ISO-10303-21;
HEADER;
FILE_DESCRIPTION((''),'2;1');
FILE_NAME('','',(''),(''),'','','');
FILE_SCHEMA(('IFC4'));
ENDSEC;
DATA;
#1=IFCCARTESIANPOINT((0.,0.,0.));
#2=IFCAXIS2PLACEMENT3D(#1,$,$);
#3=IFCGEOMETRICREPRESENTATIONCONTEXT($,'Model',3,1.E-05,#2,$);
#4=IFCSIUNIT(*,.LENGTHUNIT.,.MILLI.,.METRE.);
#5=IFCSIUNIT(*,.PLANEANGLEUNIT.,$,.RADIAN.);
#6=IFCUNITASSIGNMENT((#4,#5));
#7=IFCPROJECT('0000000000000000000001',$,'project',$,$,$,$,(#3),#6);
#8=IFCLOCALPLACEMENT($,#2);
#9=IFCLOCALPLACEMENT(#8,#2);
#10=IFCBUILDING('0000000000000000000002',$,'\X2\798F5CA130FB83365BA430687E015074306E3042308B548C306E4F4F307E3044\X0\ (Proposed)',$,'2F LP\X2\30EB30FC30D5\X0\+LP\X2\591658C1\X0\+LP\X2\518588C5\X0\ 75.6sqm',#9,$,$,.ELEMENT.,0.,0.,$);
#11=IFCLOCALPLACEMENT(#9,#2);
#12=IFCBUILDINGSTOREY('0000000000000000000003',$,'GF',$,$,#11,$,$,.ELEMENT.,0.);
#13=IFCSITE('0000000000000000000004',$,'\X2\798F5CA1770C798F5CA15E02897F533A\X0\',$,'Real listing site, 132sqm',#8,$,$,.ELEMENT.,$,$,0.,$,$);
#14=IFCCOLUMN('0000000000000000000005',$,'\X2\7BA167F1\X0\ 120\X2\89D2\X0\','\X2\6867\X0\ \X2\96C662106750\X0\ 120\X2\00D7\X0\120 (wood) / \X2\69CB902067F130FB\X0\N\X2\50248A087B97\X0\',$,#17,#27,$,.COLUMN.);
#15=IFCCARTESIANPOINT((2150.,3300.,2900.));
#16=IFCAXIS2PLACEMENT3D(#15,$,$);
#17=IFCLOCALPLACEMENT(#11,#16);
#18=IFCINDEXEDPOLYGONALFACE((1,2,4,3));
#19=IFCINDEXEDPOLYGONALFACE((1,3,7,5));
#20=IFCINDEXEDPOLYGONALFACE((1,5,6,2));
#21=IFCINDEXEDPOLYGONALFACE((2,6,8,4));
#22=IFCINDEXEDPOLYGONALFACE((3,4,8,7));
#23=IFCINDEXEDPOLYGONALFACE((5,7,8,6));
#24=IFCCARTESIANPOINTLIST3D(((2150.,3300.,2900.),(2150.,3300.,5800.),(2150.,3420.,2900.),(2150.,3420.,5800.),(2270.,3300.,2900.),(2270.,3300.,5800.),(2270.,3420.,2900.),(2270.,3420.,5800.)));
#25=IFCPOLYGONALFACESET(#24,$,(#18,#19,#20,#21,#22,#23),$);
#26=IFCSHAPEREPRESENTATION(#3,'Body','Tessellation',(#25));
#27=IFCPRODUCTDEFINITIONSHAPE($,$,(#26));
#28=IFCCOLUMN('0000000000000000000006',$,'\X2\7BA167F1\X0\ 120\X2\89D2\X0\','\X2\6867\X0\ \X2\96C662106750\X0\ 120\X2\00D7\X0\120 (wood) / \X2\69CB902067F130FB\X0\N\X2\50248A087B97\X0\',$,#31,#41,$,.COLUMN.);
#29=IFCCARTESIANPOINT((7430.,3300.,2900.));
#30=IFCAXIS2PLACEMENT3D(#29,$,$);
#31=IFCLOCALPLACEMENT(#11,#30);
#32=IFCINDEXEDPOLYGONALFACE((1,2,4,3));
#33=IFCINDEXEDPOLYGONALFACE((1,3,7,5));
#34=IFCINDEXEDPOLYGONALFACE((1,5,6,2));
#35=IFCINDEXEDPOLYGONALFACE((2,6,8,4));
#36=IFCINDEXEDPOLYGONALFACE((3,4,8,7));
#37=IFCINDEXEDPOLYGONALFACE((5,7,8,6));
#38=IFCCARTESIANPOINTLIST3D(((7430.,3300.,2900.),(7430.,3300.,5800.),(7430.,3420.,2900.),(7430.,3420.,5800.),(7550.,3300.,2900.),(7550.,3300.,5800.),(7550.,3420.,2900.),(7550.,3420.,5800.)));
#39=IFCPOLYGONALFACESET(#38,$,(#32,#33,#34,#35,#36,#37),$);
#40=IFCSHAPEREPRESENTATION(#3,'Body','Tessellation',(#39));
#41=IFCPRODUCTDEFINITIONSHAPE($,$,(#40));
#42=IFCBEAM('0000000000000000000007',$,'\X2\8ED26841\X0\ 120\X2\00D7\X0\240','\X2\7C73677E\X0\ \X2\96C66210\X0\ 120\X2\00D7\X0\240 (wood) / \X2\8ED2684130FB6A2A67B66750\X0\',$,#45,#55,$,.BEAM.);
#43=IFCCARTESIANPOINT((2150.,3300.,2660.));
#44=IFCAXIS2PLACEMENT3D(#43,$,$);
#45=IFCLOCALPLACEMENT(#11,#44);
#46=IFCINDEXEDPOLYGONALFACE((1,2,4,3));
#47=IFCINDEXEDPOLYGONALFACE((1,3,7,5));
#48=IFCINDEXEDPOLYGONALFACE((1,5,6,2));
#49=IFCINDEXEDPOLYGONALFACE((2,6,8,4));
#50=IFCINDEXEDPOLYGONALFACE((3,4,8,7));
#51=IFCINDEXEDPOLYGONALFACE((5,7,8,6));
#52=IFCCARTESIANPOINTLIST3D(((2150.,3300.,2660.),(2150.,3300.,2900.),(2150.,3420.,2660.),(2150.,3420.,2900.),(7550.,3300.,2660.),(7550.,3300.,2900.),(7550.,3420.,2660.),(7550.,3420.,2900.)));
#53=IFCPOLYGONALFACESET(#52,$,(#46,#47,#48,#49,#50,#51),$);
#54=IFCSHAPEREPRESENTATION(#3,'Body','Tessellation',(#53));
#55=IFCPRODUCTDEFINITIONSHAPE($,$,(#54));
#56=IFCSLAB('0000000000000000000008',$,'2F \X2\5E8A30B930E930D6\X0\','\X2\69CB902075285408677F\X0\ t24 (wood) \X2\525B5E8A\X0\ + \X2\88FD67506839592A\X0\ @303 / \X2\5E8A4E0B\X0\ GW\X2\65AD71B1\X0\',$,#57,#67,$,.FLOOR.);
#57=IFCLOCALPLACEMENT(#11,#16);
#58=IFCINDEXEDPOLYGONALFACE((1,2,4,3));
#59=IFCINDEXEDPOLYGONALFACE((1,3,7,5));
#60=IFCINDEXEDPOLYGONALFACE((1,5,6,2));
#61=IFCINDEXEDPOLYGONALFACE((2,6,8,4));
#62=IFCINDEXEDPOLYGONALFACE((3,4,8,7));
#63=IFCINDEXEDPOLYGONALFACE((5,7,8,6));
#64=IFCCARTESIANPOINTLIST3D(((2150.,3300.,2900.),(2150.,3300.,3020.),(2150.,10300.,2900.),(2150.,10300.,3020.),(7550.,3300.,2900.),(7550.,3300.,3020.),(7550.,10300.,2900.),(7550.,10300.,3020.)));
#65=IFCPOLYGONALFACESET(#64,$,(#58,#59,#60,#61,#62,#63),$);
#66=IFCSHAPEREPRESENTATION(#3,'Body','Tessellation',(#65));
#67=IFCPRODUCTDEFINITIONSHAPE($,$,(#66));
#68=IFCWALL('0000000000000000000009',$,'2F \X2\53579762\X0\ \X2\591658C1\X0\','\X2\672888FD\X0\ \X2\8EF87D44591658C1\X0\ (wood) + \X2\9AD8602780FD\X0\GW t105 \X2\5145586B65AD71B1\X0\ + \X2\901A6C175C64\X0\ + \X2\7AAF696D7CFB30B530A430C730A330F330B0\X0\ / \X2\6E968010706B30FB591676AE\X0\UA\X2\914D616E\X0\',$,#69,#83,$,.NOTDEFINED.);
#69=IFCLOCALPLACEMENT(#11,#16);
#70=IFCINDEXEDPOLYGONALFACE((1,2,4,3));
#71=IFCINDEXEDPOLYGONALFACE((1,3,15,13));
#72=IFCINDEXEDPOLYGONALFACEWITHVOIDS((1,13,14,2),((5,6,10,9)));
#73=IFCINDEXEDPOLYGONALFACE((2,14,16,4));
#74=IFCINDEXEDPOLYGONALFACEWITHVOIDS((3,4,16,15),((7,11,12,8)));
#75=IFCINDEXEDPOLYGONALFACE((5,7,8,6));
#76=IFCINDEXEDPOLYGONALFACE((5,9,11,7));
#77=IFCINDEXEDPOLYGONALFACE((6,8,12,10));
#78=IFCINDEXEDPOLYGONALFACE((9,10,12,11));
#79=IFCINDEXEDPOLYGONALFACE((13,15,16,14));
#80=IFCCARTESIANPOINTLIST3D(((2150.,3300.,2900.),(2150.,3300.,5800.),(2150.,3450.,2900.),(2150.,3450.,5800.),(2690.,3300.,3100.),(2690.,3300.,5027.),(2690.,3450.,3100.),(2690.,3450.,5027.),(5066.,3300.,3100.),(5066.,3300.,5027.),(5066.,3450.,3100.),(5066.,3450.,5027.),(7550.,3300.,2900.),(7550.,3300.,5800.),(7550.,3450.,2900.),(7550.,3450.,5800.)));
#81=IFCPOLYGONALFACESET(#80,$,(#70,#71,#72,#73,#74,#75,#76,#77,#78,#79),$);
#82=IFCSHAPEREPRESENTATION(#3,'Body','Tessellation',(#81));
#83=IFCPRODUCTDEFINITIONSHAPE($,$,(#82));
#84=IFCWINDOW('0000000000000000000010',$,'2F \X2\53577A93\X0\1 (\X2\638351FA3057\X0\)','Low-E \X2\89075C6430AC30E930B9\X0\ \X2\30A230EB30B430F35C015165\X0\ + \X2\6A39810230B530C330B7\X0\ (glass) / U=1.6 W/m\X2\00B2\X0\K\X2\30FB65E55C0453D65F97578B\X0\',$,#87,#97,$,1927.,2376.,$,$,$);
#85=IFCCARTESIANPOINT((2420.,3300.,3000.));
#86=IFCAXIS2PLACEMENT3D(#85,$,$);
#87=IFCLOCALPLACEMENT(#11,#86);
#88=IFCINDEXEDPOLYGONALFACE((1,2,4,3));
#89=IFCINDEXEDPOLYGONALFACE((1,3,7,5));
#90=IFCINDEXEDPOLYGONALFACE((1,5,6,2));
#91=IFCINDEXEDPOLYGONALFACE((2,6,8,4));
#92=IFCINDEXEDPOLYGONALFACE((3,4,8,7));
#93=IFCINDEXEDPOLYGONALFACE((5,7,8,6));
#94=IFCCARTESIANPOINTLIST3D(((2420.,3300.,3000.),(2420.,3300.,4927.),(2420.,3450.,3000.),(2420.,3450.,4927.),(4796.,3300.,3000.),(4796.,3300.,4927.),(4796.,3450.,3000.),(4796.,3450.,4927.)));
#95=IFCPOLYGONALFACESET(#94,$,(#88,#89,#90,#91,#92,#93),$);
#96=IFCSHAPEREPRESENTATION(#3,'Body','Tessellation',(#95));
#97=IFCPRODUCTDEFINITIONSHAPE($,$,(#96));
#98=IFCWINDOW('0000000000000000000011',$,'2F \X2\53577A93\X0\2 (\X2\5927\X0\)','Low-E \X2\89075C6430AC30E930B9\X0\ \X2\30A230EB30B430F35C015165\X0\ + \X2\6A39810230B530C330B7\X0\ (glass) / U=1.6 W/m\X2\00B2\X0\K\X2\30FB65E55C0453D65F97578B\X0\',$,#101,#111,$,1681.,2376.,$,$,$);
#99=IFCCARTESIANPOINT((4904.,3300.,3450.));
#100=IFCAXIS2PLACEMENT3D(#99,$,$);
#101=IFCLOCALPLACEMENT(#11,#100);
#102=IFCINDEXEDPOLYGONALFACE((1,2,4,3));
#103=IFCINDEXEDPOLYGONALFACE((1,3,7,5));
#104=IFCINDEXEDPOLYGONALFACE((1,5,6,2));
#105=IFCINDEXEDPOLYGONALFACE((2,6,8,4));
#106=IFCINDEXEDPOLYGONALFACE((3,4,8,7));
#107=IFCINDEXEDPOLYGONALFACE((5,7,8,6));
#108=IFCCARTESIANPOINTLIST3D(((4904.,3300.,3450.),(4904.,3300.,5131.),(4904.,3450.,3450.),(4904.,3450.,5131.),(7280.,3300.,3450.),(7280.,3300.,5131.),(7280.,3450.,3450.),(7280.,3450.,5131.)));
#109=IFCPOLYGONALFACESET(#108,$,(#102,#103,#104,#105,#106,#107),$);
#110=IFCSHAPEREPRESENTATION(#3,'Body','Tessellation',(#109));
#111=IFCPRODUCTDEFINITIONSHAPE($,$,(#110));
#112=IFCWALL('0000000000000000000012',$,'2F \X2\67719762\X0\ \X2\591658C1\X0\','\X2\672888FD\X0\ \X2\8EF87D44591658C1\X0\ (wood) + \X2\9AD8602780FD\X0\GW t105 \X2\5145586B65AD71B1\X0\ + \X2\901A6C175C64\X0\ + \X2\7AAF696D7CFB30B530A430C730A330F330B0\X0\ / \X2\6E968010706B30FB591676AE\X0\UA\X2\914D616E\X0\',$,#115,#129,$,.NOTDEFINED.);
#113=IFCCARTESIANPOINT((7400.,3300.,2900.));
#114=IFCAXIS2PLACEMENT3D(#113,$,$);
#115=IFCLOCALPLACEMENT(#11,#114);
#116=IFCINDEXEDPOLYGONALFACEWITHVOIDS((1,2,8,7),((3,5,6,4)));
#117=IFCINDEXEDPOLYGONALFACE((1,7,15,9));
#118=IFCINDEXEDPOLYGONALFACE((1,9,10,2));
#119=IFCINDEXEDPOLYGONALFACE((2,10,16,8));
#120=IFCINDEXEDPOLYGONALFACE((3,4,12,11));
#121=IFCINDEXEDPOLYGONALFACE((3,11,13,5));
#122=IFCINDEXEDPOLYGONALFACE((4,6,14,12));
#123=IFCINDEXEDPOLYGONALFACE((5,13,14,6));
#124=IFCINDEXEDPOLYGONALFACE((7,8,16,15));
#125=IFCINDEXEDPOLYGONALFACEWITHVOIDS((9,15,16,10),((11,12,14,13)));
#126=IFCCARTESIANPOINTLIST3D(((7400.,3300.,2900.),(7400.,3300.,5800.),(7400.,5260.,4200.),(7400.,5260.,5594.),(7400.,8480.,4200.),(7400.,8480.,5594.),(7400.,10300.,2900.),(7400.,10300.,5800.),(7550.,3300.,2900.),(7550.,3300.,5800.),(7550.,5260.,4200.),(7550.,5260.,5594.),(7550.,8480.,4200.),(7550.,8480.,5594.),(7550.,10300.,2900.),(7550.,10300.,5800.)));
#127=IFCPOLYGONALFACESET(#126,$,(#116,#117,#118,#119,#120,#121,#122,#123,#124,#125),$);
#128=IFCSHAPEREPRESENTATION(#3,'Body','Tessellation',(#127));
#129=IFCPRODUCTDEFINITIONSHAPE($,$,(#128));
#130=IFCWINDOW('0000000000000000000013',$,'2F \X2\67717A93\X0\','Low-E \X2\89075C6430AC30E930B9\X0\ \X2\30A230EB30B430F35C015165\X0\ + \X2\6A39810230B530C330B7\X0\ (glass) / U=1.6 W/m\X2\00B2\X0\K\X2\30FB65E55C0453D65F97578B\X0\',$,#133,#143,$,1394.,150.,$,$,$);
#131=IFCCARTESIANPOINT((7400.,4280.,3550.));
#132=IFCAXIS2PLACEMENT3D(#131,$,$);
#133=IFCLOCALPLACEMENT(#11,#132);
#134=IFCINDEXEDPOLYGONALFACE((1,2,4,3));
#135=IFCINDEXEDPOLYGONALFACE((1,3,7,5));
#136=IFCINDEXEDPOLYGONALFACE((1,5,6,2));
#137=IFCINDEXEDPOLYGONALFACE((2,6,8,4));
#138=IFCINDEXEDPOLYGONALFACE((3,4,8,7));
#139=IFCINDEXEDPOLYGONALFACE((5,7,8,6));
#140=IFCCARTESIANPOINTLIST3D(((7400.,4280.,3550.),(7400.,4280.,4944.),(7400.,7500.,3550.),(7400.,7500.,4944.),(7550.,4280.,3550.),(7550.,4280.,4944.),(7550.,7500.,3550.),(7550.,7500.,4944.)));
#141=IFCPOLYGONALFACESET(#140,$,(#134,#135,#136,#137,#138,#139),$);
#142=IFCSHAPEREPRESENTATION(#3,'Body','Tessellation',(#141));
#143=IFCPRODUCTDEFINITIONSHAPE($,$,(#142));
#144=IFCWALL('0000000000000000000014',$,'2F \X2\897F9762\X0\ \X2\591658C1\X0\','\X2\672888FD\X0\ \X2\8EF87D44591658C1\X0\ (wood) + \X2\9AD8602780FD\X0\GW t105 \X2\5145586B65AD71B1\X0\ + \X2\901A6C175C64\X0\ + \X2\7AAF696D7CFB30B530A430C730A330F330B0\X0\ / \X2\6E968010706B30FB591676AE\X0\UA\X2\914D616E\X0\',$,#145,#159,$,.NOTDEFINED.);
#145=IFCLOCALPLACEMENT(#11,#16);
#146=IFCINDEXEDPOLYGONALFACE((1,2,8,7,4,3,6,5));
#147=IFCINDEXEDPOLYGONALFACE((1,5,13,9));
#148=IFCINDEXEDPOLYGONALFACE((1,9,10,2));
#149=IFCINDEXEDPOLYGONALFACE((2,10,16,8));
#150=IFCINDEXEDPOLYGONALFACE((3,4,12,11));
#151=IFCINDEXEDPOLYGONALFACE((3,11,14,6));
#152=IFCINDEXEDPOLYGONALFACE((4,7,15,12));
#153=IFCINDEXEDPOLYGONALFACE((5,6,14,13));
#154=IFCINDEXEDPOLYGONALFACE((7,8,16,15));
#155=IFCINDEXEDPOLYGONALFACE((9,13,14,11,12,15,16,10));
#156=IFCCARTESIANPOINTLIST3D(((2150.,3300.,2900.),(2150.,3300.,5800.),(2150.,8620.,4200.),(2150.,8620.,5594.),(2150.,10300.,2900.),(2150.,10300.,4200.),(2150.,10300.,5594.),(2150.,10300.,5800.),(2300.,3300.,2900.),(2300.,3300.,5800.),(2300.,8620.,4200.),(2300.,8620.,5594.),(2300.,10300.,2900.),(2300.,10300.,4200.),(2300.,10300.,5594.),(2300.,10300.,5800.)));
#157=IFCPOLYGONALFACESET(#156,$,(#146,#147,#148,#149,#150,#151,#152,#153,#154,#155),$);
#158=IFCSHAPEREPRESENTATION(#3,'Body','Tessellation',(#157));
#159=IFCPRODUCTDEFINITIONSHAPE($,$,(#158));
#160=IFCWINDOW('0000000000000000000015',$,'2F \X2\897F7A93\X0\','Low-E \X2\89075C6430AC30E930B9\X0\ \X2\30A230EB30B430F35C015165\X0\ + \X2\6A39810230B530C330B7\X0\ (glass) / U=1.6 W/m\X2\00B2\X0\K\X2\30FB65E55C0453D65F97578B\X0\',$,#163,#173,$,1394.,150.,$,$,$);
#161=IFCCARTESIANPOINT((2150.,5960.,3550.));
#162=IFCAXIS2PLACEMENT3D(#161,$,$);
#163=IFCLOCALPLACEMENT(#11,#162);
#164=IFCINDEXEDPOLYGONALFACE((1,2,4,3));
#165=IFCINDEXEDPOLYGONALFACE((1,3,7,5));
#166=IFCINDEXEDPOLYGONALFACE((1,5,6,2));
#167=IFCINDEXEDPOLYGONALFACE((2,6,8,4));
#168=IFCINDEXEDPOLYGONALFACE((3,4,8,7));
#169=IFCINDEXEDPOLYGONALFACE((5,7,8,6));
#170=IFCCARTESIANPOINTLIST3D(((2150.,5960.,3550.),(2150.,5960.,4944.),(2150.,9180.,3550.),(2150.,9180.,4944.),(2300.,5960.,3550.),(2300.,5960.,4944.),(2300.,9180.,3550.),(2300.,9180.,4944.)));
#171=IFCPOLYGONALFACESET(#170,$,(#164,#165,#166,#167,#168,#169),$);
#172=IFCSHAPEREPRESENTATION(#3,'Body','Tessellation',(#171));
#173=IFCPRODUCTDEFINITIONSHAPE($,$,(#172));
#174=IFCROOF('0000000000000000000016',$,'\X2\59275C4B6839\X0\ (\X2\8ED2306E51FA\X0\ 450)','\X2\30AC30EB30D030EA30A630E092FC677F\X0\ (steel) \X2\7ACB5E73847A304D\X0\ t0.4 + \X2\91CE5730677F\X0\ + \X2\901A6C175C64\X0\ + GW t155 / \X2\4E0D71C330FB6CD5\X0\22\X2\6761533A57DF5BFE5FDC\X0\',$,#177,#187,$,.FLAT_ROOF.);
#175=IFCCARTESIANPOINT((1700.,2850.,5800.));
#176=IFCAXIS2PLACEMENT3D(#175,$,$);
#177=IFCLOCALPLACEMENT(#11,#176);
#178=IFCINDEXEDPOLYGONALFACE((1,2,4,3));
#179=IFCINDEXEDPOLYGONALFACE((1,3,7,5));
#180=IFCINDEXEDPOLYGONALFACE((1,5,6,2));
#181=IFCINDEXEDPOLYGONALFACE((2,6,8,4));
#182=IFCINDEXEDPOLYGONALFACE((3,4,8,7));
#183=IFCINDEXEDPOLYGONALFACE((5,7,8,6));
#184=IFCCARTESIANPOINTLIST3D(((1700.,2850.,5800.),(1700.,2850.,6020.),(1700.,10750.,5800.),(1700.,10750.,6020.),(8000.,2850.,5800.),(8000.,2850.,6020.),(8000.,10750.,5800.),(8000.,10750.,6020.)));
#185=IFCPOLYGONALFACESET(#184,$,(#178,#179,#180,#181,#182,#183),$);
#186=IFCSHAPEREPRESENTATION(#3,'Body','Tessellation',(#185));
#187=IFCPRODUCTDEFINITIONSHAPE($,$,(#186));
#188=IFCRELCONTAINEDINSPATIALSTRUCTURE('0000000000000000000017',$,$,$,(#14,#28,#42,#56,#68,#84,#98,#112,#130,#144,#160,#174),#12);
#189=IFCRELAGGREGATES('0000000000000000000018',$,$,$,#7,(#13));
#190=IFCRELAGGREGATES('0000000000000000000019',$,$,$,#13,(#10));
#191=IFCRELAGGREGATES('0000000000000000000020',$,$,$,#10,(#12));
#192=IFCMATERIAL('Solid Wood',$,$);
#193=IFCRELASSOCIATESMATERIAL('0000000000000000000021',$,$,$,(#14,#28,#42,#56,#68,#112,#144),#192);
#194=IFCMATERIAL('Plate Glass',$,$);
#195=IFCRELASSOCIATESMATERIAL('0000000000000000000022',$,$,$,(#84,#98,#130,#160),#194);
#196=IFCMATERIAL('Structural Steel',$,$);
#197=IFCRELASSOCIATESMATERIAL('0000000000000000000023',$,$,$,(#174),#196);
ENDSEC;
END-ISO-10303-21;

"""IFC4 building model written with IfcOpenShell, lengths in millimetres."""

from ifc_helpers import new_model, si_unit, frame, frame_2d, origin, place, context, project, spatial, rectangle, extrude, material, element, fill, save


model = new_model("IFC4")

# Units and contexts
model_context = context("Model", 3, precision=1e-05, world=origin())
ifc_project = project(units=[si_unit("LENGTHUNIT", "METRE", prefix="MILLI"), si_unit("PLANEANGLEUNIT", "RADIAN")], contexts=[model_context])

# Site, building, storey
site_placement = place(None, origin())
site = spatial("IfcSite", under=ifc_project, at=site_placement, Name="福岡県福岡市西区", ObjectType="Real listing site, 132sqm", CompositionType="ELEMENT", RefElevation=0.0)
building_placement = place(site_placement, origin())
building = spatial("IfcBuilding", under=site, at=building_placement, Name="福岡・茶室と縁側のある和の住まい (Proposed)", ObjectType="2F LPルーフ+LP外壁+LP内装 75.6sqm", CompositionType="ELEMENT", ElevationOfRefHeight=0.0, ElevationOfTerrain=0.0)
storey_placement = place(building_placement, origin())
storey = spatial("IfcBuildingStorey", under=building, at=storey_placement, Name="GF", CompositionType="ELEMENT", Elevation=0.0)

# Columns
ifc_material_1 = material(Name="Solid Wood")
column_1_placement = place(storey_placement, frame((2150.0, 3300.0, 2900.0)))
element("IfcColumn", 1, at=column_1_placement, inside=storey, material=ifc_material_1, Name="管柱 120角", Description="桧 集成材 120×120 (wood) / 構造柱・N値計算", PredefinedType="COLUMN", context=model_context, shape_type="SweptSolid", body=[
    extrude(rectangle(XDim=120.0, YDim=120.0, at=frame_2d((60.0, 60.0))), frame((2150.0, 3300.0, 2900.0)), (0.0, 0.0, 1.0), 2900.0),
])
column_2_placement = place(storey_placement, frame((7430.0, 3300.0, 2900.0)))
element("IfcColumn", 2, at=column_2_placement, inside=storey, material=ifc_material_1, Name="管柱 120角", Description="桧 集成材 120×120 (wood) / 構造柱・N値計算", PredefinedType="COLUMN", context=model_context, shape_type="SweptSolid", body=[
    extrude(rectangle(XDim=120.0, YDim=120.0, at=frame_2d((60.0, 60.0))), frame((7430.0, 3300.0, 2900.0)), (0.0, 0.0, 1.0), 2900.0),
])

# Beam
beam_1_placement = place(storey_placement, frame((2150.0, 3300.0, 2660.0)))
element("IfcBeam", 3, at=beam_1_placement, inside=storey, material=ifc_material_1, Name="軒桁 120×240", Description="米松 集成 120×240 (wood) / 軒桁・横架材", PredefinedType="BEAM", context=model_context, shape_type="SweptSolid", body=[
    extrude(rectangle(XDim=5400.0, YDim=120.0, at=frame_2d((2700.0, 60.0))), frame((2150.0, 3300.0, 2660.0)), (0.0, 0.0, 1.0), 240.0),
])

# Slab
slab_placement = place(storey_placement, frame((2150.0, 3300.0, 2900.0)))
element("IfcSlab", 4, at=slab_placement, inside=storey, material=ifc_material_1, Name="2F 床スラブ", Description="構造用合板 t24 (wood) 剛床 + 製材根太 @303 / 床下 GW断熱", PredefinedType="FLOOR", context=model_context, shape_type="SweptSolid", body=[
    extrude(rectangle(XDim=5400.0, YDim=7000.0, at=frame_2d((2700.0, 3500.0))), frame((2150.0, 3300.0, 2900.0)), (0.0, 0.0, 1.0), 120.0),
])

# Wall, openings, windows
wall_1_placement = place(storey_placement, frame((2150.0, 3300.0, 2900.0)))
wall_1 = element("IfcWall", 5, at=wall_1_placement, inside=storey, material=ifc_material_1, Name="2F 南面 外壁", Description="木製 軸組外壁 (wood) + 高性能GW t105 充填断熱 + 通気層 + 窯業系サイディング / 準耐火・外皮UA配慮", PredefinedType="NOTDEFINED", context=model_context, shape_type="SweptSolid", body=[
    extrude(rectangle(XDim=5400.0, YDim=150.0, at=frame_2d((2700.0, 75.0))), frame((2150.0, 3300.0, 2900.0)), (0.0, 0.0, 1.0), 2900.0),
])
opening_1_placement = place(storey_placement, frame((2420.0, 3300.0, 3000.0)))
opening_1 = element("IfcOpeningElement", 6, at=opening_1_placement, cuts=wall_1, PredefinedType="NOTDEFINED", context=model_context, shape_type="SweptSolid", body=[
    extrude(rectangle(XDim=2376.0, YDim=150.0, at=frame_2d((1188.0, 75.0))), frame((2420.0, 3300.0, 3000.0)), (0.0, 0.0, 1.0), 1927.0),
])
opening_2_placement = place(storey_placement, frame((4904.0, 3300.0, 3450.0)))
opening_2 = element("IfcOpeningElement", 7, at=opening_2_placement, cuts=wall_1, PredefinedType="NOTDEFINED", context=model_context, shape_type="SweptSolid", body=[
    extrude(rectangle(XDim=2376.0, YDim=150.0, at=frame_2d((1188.0, 75.0))), frame((4904.0, 3300.0, 3450.0)), (0.0, 0.0, 1.0), 1681.0),
])
ifc_material_2 = material(Name="Plate Glass")
window_1_placement = place(storey_placement, frame((2420.0, 3300.0, 3000.0)))
window_1 = element("IfcWindow", 8, at=window_1_placement, inside=storey, material=ifc_material_2, Name="2F 南窓1 (掃出し)", Description="Low-E 複層ガラス アルゴン封入 + 樹脂サッシ (glass) / U=1.6 W/m²K・日射取得型", OverallHeight=1927.0, OverallWidth=2376.0, context=model_context, shape_type="SweptSolid", body=[
    extrude(rectangle(XDim=2376.0, YDim=150.0, at=frame_2d((1188.0, 75.0))), frame((2420.0, 3300.0, 3000.0)), (0.0, 0.0, 1.0), 1927.0),
])
fill(opening_1, window_1)
window_2_placement = place(storey_placement, frame((4904.0, 3300.0, 3450.0)))
window_2 = element("IfcWindow", 9, at=window_2_placement, inside=storey, material=ifc_material_2, Name="2F 南窓2 (大)", Description="Low-E 複層ガラス アルゴン封入 + 樹脂サッシ (glass) / U=1.6 W/m²K・日射取得型", OverallHeight=1681.0, OverallWidth=2376.0, context=model_context, shape_type="SweptSolid", body=[
    extrude(rectangle(XDim=2376.0, YDim=150.0, at=frame_2d((1188.0, 75.0))), frame((4904.0, 3300.0, 3450.0)), (0.0, 0.0, 1.0), 1681.0),
])
fill(opening_2, window_2)

# Walls, openings, windows
wall_2_placement = place(storey_placement, frame((7400.0, 3300.0, 2900.0)))
wall_2 = element("IfcWall", 10, at=wall_2_placement, inside=storey, material=ifc_material_1, Name="2F 東面 外壁", Description="木製 軸組外壁 (wood) + 高性能GW t105 充填断熱 + 通気層 + 窯業系サイディング / 準耐火・外皮UA配慮", PredefinedType="NOTDEFINED", context=model_context, shape_type="SweptSolid", body=[
    extrude(rectangle(XDim=150.0, YDim=7000.0, at=frame_2d((75.0, 3500.0))), frame((7400.0, 3300.0, 2900.0)), (0.0, 0.0, 1.0), 2900.0),
])
opening_3_placement = place(storey_placement, frame((7400.0, 4280.0, 3550.0)))
opening_3 = element("IfcOpeningElement", 11, at=opening_3_placement, cuts=wall_2, PredefinedType="NOTDEFINED", context=model_context, shape_type="SweptSolid", body=[
    extrude(rectangle(XDim=150.0, YDim=3220.0, at=frame_2d((75.0, 1610.0))), frame((7400.0, 4280.0, 3550.0)), (0.0, 0.0, 1.0), 1394.0),
])
window_3_placement = place(storey_placement, frame((7400.0, 4280.0, 3550.0)))
window_3 = element("IfcWindow", 12, at=window_3_placement, inside=storey, material=ifc_material_2, Name="2F 東窓", Description="Low-E 複層ガラス アルゴン封入 + 樹脂サッシ (glass) / U=1.6 W/m²K・日射取得型", OverallHeight=1394.0, OverallWidth=150.0, context=model_context, shape_type="SweptSolid", body=[
    extrude(rectangle(XDim=150.0, YDim=3220.0, at=frame_2d((75.0, 1610.0))), frame((7400.0, 4280.0, 3550.0)), (0.0, 0.0, 1.0), 1394.0),
])
fill(opening_3, window_3)
wall_3_placement = place(storey_placement, frame((2150.0, 3300.0, 2900.0)))
wall_3 = element("IfcWall", 13, at=wall_3_placement, inside=storey, material=ifc_material_1, Name="2F 西面 外壁", Description="木製 軸組外壁 (wood) + 高性能GW t105 充填断熱 + 通気層 + 窯業系サイディング / 準耐火・外皮UA配慮", PredefinedType="NOTDEFINED", context=model_context, shape_type="SweptSolid", body=[
    extrude(rectangle(XDim=150.0, YDim=7000.0, at=frame_2d((75.0, 3500.0))), frame((2150.0, 3300.0, 2900.0)), (0.0, 0.0, 1.0), 2900.0),
])
opening_4_placement = place(storey_placement, frame((2150.0, 5960.0, 3550.0)))
opening_4 = element("IfcOpeningElement", 14, at=opening_4_placement, cuts=wall_3, PredefinedType="NOTDEFINED", context=model_context, shape_type="SweptSolid", body=[
    extrude(rectangle(XDim=150.0, YDim=3220.0, at=frame_2d((75.0, 1610.0))), frame((2150.0, 5960.0, 3550.0)), (0.0, 0.0, 1.0), 1394.0),
])
window_4_placement = place(storey_placement, frame((2150.0, 5960.0, 3550.0)))
window_4 = element("IfcWindow", 15, at=window_4_placement, inside=storey, material=ifc_material_2, Name="2F 西窓", Description="Low-E 複層ガラス アルゴン封入 + 樹脂サッシ (glass) / U=1.6 W/m²K・日射取得型", OverallHeight=1394.0, OverallWidth=150.0, context=model_context, shape_type="SweptSolid", body=[
    extrude(rectangle(XDim=150.0, YDim=3220.0, at=frame_2d((75.0, 1610.0))), frame((2150.0, 5960.0, 3550.0)), (0.0, 0.0, 1.0), 1394.0),
])
fill(opening_4, window_4)

# Roof
ifc_material_3 = material(Name="Structural Steel")
roof_placement = place(storey_placement, frame((1700.0, 2850.0, 5800.0)))
element("IfcRoof", 16, at=roof_placement, inside=storey, material=ifc_material_3, Name="大屋根 (軒の出 450)", Description="ガルバリウム鋼板 (steel) 立平葺き t0.4 + 野地板 + 通気層 + GW t155 / 不燃・法22条区域対応", PredefinedType="FLAT_ROOF", context=model_context, shape_type="SweptSolid", body=[
    extrude(rectangle(XDim=6300.0, YDim=7900.0, at=frame_2d((3150.0, 3950.0))), frame((1700.0, 2850.0, 5800.0)), (0.0, 0.0, 1.0), 220.0),
])

save(model, "model.ifc")
